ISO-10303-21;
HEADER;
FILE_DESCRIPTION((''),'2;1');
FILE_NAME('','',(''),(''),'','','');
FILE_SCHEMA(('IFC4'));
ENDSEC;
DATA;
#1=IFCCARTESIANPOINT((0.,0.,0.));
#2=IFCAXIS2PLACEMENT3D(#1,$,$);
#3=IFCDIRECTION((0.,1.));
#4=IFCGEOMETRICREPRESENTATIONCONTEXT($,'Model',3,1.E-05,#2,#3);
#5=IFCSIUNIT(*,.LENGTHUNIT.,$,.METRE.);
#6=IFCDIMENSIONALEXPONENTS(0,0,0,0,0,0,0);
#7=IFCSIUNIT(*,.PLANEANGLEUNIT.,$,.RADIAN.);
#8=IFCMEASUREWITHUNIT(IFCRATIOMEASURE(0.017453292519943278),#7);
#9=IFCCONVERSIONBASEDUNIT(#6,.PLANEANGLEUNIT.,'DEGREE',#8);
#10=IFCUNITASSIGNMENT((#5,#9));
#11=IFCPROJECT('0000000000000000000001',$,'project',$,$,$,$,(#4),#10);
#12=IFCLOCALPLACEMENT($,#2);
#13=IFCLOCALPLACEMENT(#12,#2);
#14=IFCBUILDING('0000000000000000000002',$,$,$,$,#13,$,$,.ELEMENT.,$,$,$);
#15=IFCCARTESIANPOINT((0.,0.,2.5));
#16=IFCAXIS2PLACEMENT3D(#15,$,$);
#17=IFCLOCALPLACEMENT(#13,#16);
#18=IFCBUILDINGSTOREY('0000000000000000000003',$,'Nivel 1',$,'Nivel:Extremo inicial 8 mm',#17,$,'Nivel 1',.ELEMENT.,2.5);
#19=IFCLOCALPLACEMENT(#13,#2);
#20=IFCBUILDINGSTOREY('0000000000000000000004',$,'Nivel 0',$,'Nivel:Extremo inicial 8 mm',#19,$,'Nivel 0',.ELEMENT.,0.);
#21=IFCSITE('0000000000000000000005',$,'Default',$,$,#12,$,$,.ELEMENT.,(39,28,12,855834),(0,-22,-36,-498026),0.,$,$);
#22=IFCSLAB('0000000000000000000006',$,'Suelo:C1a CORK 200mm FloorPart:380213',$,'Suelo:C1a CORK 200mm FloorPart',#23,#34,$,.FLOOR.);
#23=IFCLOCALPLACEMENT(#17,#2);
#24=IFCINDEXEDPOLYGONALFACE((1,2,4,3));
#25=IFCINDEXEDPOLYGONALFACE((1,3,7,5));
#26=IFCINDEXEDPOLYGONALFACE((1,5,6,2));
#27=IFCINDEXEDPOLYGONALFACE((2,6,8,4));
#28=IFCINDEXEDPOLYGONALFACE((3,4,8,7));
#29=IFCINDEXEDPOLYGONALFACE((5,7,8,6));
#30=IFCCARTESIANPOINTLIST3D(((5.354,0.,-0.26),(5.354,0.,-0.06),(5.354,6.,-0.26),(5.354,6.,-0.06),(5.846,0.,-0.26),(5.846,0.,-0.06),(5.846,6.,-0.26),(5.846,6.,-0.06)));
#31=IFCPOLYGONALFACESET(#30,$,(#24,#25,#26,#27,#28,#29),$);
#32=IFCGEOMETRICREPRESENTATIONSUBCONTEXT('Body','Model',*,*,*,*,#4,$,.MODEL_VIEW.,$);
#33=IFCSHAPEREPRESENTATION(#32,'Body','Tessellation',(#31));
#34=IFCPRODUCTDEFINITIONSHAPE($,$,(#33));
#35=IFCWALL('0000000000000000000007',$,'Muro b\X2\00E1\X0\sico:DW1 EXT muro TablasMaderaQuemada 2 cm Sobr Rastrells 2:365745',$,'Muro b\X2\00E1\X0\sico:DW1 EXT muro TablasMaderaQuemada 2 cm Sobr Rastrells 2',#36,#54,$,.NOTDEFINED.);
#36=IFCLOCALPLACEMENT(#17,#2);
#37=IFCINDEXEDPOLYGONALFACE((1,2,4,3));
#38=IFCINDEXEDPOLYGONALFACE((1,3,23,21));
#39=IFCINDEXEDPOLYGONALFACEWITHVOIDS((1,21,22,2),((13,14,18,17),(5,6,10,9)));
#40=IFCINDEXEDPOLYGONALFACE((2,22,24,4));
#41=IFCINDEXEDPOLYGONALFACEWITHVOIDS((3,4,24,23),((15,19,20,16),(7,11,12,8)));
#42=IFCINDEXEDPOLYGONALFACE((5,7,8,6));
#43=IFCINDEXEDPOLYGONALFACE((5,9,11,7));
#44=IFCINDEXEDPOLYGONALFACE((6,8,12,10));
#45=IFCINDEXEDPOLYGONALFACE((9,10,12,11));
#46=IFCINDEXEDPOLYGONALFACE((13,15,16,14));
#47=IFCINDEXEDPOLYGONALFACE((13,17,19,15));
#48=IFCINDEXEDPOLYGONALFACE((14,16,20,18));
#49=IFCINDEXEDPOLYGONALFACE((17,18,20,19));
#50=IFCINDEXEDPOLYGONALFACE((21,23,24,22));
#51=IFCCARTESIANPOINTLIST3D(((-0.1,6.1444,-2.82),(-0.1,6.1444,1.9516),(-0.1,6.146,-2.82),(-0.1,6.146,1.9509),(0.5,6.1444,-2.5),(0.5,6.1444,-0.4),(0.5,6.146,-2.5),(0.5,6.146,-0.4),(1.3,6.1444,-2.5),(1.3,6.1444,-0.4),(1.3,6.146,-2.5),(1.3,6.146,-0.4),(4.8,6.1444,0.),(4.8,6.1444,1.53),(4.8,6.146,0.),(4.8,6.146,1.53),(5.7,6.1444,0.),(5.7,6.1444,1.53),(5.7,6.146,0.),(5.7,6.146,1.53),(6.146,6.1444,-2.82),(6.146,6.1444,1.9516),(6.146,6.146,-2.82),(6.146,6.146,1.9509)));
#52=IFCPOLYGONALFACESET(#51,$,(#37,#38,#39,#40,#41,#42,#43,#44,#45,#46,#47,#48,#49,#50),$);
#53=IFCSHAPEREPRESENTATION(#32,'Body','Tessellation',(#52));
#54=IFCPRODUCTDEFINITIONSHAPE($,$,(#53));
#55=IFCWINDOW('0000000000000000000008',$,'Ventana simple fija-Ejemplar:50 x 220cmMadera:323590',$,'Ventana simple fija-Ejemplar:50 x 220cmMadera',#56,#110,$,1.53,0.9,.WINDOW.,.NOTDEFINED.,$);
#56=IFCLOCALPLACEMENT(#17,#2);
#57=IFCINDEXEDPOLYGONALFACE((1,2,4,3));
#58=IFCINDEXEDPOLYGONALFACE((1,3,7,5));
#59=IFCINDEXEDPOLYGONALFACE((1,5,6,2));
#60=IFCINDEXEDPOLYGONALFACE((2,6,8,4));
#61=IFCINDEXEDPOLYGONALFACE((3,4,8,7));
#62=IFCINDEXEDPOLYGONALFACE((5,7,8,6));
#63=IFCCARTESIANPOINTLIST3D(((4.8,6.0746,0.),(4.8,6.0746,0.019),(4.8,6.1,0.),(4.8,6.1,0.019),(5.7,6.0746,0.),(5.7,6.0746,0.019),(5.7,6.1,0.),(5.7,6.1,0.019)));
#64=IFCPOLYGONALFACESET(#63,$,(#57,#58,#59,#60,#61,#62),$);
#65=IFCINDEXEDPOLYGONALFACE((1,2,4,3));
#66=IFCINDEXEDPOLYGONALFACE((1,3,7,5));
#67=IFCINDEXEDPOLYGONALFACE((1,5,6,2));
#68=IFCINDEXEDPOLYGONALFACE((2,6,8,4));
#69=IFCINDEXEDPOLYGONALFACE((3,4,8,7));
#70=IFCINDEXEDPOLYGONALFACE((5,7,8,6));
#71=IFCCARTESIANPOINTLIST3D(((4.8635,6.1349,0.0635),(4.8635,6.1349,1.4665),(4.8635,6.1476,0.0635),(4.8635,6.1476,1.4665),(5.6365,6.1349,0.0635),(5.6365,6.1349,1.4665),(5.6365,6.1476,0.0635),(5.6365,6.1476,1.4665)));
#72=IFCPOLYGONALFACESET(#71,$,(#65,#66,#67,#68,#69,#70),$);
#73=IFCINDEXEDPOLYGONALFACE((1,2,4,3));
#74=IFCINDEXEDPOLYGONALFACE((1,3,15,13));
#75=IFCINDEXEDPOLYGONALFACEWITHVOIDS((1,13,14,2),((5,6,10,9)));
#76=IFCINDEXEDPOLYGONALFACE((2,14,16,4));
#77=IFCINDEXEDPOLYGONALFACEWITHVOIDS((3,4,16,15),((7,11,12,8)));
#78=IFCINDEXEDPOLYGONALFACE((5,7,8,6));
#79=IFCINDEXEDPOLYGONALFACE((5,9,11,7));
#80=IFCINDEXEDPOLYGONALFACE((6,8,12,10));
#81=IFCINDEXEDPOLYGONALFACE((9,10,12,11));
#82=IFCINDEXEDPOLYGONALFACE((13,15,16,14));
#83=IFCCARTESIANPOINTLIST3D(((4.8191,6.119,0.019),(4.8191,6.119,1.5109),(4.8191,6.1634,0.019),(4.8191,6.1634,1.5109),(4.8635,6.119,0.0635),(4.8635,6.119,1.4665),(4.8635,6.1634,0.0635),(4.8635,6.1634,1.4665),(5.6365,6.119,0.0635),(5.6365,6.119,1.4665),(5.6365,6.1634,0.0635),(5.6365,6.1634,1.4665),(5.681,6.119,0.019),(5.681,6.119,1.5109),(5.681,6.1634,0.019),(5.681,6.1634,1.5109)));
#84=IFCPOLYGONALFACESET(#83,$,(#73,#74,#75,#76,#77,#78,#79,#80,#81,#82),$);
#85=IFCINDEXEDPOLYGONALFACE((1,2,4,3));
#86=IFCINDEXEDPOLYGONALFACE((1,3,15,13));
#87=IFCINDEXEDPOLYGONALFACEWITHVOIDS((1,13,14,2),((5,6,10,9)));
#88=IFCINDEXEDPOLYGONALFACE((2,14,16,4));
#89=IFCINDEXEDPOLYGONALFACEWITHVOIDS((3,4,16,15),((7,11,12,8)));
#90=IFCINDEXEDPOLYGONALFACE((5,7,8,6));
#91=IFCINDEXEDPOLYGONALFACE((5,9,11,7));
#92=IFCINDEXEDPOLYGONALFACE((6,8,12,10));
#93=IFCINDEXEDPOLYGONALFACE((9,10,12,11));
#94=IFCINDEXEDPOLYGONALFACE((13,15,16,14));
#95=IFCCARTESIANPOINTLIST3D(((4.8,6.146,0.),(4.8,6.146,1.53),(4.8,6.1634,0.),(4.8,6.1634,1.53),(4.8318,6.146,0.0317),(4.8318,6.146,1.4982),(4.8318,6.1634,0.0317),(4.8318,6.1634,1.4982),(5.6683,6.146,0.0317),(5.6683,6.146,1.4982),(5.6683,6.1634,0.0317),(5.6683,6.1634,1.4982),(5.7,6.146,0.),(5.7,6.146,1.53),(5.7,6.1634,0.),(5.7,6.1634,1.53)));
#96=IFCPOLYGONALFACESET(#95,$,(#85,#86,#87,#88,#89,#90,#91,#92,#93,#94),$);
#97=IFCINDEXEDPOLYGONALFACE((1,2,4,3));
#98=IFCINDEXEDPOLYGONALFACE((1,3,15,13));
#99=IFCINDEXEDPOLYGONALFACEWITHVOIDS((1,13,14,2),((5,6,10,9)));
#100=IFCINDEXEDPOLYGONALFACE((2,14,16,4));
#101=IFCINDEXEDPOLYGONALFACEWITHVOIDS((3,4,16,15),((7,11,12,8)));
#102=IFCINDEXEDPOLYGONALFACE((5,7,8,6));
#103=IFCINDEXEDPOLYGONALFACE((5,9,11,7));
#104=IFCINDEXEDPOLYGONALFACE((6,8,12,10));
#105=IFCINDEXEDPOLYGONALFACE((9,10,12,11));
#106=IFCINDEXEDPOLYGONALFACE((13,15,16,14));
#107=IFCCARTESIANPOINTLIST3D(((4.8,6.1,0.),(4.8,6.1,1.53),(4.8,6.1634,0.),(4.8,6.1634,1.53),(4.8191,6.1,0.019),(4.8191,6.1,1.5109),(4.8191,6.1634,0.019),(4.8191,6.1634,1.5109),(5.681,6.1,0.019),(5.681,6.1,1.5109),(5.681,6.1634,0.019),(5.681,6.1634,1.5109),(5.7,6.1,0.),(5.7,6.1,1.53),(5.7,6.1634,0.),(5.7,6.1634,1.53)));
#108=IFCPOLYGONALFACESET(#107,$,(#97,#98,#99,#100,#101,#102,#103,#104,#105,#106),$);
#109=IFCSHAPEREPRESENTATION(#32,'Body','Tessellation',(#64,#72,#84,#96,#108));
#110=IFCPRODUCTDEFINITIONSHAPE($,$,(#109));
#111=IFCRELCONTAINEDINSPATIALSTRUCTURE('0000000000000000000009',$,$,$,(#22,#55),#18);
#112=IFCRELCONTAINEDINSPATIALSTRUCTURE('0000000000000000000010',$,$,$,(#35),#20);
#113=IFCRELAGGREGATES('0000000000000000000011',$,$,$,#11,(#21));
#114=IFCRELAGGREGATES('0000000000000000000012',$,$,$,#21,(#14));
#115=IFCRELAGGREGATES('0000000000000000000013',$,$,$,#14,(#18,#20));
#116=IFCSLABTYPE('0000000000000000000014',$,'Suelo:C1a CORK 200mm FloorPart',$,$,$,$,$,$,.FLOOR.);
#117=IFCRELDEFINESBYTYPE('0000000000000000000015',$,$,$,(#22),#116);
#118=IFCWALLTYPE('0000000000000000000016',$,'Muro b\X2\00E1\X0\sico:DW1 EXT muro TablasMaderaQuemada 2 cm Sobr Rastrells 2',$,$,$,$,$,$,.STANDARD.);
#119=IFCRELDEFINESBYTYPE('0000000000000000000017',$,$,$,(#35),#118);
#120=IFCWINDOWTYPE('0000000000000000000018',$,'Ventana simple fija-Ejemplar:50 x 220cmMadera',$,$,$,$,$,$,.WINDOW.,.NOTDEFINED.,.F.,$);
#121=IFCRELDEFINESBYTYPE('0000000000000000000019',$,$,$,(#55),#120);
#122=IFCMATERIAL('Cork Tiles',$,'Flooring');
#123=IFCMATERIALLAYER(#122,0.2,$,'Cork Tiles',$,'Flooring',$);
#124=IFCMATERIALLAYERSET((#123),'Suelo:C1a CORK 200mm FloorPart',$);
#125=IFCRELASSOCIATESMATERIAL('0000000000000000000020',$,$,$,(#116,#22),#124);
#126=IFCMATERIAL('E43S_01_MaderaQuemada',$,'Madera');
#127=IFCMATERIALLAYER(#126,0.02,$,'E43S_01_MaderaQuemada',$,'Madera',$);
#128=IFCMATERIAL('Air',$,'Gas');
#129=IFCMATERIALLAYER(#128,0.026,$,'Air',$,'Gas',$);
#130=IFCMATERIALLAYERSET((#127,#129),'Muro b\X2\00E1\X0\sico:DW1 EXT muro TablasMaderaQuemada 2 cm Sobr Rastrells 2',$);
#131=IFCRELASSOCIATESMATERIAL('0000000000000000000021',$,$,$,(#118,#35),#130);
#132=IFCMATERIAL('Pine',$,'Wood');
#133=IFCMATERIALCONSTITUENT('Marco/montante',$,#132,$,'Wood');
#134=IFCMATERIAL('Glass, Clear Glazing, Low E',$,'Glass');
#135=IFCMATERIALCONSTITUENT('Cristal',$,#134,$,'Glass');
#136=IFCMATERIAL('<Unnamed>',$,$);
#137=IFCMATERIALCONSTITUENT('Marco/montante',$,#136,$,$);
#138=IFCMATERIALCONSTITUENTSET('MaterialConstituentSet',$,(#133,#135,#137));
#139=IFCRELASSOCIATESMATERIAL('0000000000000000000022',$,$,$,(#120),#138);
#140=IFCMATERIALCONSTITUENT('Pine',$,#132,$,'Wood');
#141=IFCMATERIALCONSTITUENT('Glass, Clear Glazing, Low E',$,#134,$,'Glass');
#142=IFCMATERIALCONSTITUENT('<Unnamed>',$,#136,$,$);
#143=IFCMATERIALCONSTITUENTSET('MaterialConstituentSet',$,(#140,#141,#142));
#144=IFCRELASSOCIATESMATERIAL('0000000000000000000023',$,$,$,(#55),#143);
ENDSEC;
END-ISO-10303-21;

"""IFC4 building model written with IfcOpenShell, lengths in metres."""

from ifc_helpers import new_model, entity, si_unit, converted_unit, direction, frame, frame_2d, origin, origin_2d_with_axis, place, context, subcontext, project, spatial, polyline, rectangle, outline, extrude, source, transform, mapped, material, layer, layer_set, layer_usage, constituent, constituent_set, type_object, type_shapes, element, fill, save


model = new_model("IFC4")

# Units and contexts
model_context = context("Model", 3, precision=1e-05, world=origin(), true_north=direction((0.0, 1.0)))
body_context = subcontext(model_context, "Body", "Model", "MODEL_VIEW")
ifc_project = project(units=[si_unit("LENGTHUNIT", "METRE"), converted_unit("PLANEANGLEUNIT", "DEGREE", entity("IfcRatioMeasure", 0.017453292519943278), si_unit("PLANEANGLEUNIT", "RADIAN"), dimensions=[0, 0, 0, 0, 0, 0, 0])], contexts=[model_context])

# Site, building, storey
site_placement = place(None, origin())
site = spatial("IfcSite", under=ifc_project, at=site_placement, Name="Default", CompositionType="ELEMENT", RefLatitude=(39, 28, 12, 855834), RefLongitude=(0, -22, -36, -498026), RefElevation=0.0)
building_placement = place(site_placement, origin())
building = spatial("IfcBuilding", under=site, at=building_placement, CompositionType="ELEMENT")
storey_1_placement = place(building_placement, frame((0.0, 0.0, 2.5)))
storey_1 = spatial("IfcBuildingStorey", under=building, at=storey_1_placement, Name="Nivel 1", ObjectType="Nivel:Extremo inicial 8 mm", LongName="Nivel 1", CompositionType="ELEMENT", Elevation=2.5)

# Slab
ifc_material_1 = material(Name="Cork Tiles", Category="Flooring")
ifc_layer_1 = layer(ifc_material_1, 0.2, Name="Cork Tiles", Category="Flooring")
ifc_layer_set_1 = layer_set([ifc_layer_1], Name="Suelo:C1a CORK 200mm FloorPart")
ifc_layer_usage_1 = layer_usage(ifc_layer_set_1, "AXIS3", "POSITIVE", 0.0)
slab_type_1 = type_object("IfcSlabType", Name="Suelo:C1a CORK 200mm FloorPart", PredefinedType="FLOOR", material=ifc_layer_set_1)
slab_1_placement = place(storey_1_placement, origin())
element("IfcSlab", 1, at=slab_1_placement, inside=storey_1, type_object=slab_type_1, material=ifc_layer_usage_1, Name="Suelo:C1a CORK 200mm FloorPart:380213", ObjectType="Suelo:C1a CORK 200mm FloorPart", PredefinedType="FLOOR", context=body_context, shape_type="SweptSolid", body=[
    extrude(rectangle(XDim=6.0, YDim=0.492, at=frame_2d((0.0, 0.0), x_axis=(1.0, 0.0))), frame((5.6, 3.0, -0.06), z_axis=(0.0, 0.0, -1.0), x_axis=(0.0, 1.0, 0.0)), (0.0, 0.0, 1.0), 0.2),
])

# Shared definitions
storey_2_placement = place(building_placement, origin())
storey_2 = spatial("IfcBuildingStorey", under=building, at=storey_2_placement, Name="Nivel 0", ObjectType="Nivel:Extremo inicial 8 mm", LongName="Nivel 0", CompositionType="ELEMENT", Elevation=0.0)

# Wall, openings, window
ifc_material_2 = material(Name="E43S_01_MaderaQuemada", Category="Madera")
ifc_layer_2 = layer(ifc_material_2, 0.02, Name="E43S_01_MaderaQuemada", Category="Madera")
ifc_material_3 = material(Name="Air", Category="Gas")
ifc_layer_3 = layer(ifc_material_3, 0.026, Name="Air", Category="Gas")
ifc_layer_set_2 = layer_set([ifc_layer_2, ifc_layer_3], Name="Muro básico:DW1 EXT muro TablasMaderaQuemada 2 cm Sobr Rastrells 2")
ifc_layer_usage_2 = layer_usage(ifc_layer_set_2, "AXIS2", "NEGATIVE", 0.023)
wall_type = type_object("IfcWallType", Name="Muro básico:DW1 EXT muro TablasMaderaQuemada 2 cm Sobr Rastrells 2", PredefinedType="STANDARD", material=ifc_layer_set_2)
wall_placement = place(storey_2_placement, frame((-0.1, 6.123, -0.32)))
wall = element("IfcWall", 2, at=wall_placement, inside=storey_2, type_object=wall_type, material=ifc_layer_usage_2, Name="Muro básico:DW1 EXT muro TablasMaderaQuemada 2 cm Sobr Rastrells 2:365745", ObjectType="Muro básico:DW1 EXT muro TablasMaderaQuemada 2 cm Sobr Rastrells 2", PredefinedType="NOTDEFINED", context=body_context, shape_type="SweptSolid", body=[
    extrude(rectangle(XDim=6.246, YDim=0.0016, at=frame_2d((3.123, 0.0222), x_axis=(-1.0, 0.0))), origin(), (0.0, 0.0, 1.0), 4.82),
])
opening_1_placement = place(storey_2_placement, frame((-0.1, 6.123, -0.32)))
element("IfcOpeningElement", 3, at=opening_1_placement, cuts=wall, PredefinedType="OPENING", context=body_context, shape_type="SweptSolid", body=[
    extrude(rectangle(XDim=0.0495, YDim=6.246, at=frame_2d((-0.6154, 0.005), x_axis=(0.0, 1.0))), frame((3.7384, -0.0046, 4.7819), z_axis=(0.0, 0.370288, 0.928917), x_axis=(1.0, 0.0, 0.0)), (0.0, 0.0, 1.0), 0.0599),
])
opening_2_placement = place(wall_placement, frame((0.6, -1.547, 0.32)))
element("IfcOpeningElement", 4, at=opening_2_placement, cuts=wall, PredefinedType="OPENING", context=body_context, shape_type="SweptSolid", body=[
    extrude(rectangle(XDim=2.1, YDim=0.8, at=frame_2d((0.0, 0.0), x_axis=(1.0, 0.0))), frame((0.4, 0.0, 1.05), z_axis=(0.0, 1.0, 0.0), x_axis=(0.0, 0.0, -1.0)), (0.0, 0.0, 1.0), 3.048),
])
opening_3_placement = place(wall_placement, frame((5.8, 0.023, 2.82)))
opening_3 = element("IfcOpeningElement", 5, at=opening_3_placement, cuts=wall, PredefinedType="OPENING", context=body_context, shape_type="SweptSolid", body=[
    extrude(rectangle(XDim=1.53, YDim=0.9, at=frame_2d((0.765, 0.45), x_axis=(-1.0, 0.0))), frame((0.0, 0.0, 0.0), z_axis=(0.0, -1.0, 0.0), x_axis=(0.0, 0.0, 1.0)), (0.0, 0.0, 1.0), 0.046),
])
ifc_material_4 = material(Name="Pine", Category="Wood")
ifc_constituent_1 = constituent(ifc_material_4, Name="Pine", Category="Wood")
ifc_material_5 = material(Name="Glass, Clear Glazing, Low E", Category="Glass")
ifc_constituent_2 = constituent(ifc_material_5, Name="Glass, Clear Glazing, Low E", Category="Glass")
ifc_material_6 = material(Name="<Unnamed>")
ifc_constituent_3 = constituent(ifc_material_6, Name="<Unnamed>")
ifc_constituent_set_1 = constituent_set(constituents=[ifc_constituent_1, ifc_constituent_2, ifc_constituent_3], Name="MaterialConstituentSet")
ifc_constituent_4 = constituent(ifc_material_4, Name="Marco/montante", Category="Wood")
ifc_constituent_5 = constituent(ifc_material_5, Name="Cristal", Category="Glass")
ifc_constituent_6 = constituent(ifc_material_6, Name="Marco/montante")
ifc_constituent_set_2 = constituent_set(constituents=[ifc_constituent_4, ifc_constituent_5, ifc_constituent_6], Name="MaterialConstituentSet")
window_type = type_object("IfcWindowType", Name="Ventana simple fija-Ejemplar:50 x 220cmMadera", ParameterTakesPrecedence=False, PartitioningType="NOTDEFINED", PredefinedType="WINDOW", material=ifc_constituent_set_2)
shared_shape = source(origin(), body_context, "Body", "SweptSolid", [
    extrude(rectangle(XDim=0.9, YDim=0.0254, at=origin_2d_with_axis()), frame((0.5262, 0.0587, 0.0), z_axis=(0.0, 0.0, 1.0), x_axis=(-1.0, 0.0, 0.0)), (0.0, 0.0, 1.0), 0.019),
    extrude(rectangle(XDim=0.773, YDim=0.0127, at=origin_2d_with_axis()), frame((0.5262, 0.0048, 0.0635)), (0.0, 0.0, 1.0), 1.403),
    extrude(outline(polyline([(-0.431, -0.7459), (0.431, -0.7459), (0.431, 0.7459), (-0.431, 0.7459), (-0.431, -0.7459)]), holes=[polyline([(-0.3865, -0.7015), (-0.3865, 0.7015), (0.3865, 0.7015), (0.3865, -0.7015), (-0.3865, -0.7015)])]), frame((0.5262, 0.027, 0.765), z_axis=(0.0, -1.0, 0.0), x_axis=(-1.0, 0.0, 0.0)), (0.0, 0.0, 1.0), 0.0444),
    extrude(outline(polyline([(-0.45, -0.765), (0.45, -0.765), (0.45, 0.765), (-0.45, 0.765), (-0.45, -0.765)]), holes=[polyline([(-0.4183, -0.7332), (-0.4183, 0.7332), (0.4183, 0.7332), (0.4183, -0.7332), (-0.4183, -0.7332)])]), frame((0.5262, 0.0, 0.765), z_axis=(0.0, -1.0, 0.0), x_axis=(-1.0, 0.0, 0.0)), (0.0, 0.0, 1.0), 0.0175),
    extrude(outline(polyline([(-0.765, -0.45), (0.765, -0.45), (0.765, 0.45), (-0.765, 0.45), (-0.765, -0.45)]), holes=[polyline([(-0.7459, -0.431), (-0.7459, 0.431), (0.7459, 0.431), (0.7459, -0.431), (-0.7459, -0.431)])]), frame((0.5262, 0.046, 0.765), z_axis=(0.0, -1.0, 0.0), x_axis=(0.0, 0.0, -1.0)), (0.0, 0.0, 1.0), 0.0635),
])
type_shapes(window_type, [shared_shape])
window_placement = place(opening_3_placement, frame((0.0762, 0.0, 0.0), z_axis=(0.0, 0.0, 1.0), x_axis=(-1.0, 0.0, 0.0)))
window = element("IfcWindow", 6, at=window_placement, inside=storey_1, type_object=window_type, material=ifc_constituent_set_1, Name="Ventana simple fija-Ejemplar:50 x 220cmMadera:323590", ObjectType="Ventana simple fija-Ejemplar:50 x 220cmMadera", OverallHeight=1.53, OverallWidth=0.9, PartitioningType="NOTDEFINED", PredefinedType="WINDOW", context=body_context, shape_type="MappedRepresentation", body=[
    mapped(shared_shape, transform((0.0, 0.0, 0.0), scale=1.0)),
])
fill(opening_3, window)

save(model, "model.ifc")
